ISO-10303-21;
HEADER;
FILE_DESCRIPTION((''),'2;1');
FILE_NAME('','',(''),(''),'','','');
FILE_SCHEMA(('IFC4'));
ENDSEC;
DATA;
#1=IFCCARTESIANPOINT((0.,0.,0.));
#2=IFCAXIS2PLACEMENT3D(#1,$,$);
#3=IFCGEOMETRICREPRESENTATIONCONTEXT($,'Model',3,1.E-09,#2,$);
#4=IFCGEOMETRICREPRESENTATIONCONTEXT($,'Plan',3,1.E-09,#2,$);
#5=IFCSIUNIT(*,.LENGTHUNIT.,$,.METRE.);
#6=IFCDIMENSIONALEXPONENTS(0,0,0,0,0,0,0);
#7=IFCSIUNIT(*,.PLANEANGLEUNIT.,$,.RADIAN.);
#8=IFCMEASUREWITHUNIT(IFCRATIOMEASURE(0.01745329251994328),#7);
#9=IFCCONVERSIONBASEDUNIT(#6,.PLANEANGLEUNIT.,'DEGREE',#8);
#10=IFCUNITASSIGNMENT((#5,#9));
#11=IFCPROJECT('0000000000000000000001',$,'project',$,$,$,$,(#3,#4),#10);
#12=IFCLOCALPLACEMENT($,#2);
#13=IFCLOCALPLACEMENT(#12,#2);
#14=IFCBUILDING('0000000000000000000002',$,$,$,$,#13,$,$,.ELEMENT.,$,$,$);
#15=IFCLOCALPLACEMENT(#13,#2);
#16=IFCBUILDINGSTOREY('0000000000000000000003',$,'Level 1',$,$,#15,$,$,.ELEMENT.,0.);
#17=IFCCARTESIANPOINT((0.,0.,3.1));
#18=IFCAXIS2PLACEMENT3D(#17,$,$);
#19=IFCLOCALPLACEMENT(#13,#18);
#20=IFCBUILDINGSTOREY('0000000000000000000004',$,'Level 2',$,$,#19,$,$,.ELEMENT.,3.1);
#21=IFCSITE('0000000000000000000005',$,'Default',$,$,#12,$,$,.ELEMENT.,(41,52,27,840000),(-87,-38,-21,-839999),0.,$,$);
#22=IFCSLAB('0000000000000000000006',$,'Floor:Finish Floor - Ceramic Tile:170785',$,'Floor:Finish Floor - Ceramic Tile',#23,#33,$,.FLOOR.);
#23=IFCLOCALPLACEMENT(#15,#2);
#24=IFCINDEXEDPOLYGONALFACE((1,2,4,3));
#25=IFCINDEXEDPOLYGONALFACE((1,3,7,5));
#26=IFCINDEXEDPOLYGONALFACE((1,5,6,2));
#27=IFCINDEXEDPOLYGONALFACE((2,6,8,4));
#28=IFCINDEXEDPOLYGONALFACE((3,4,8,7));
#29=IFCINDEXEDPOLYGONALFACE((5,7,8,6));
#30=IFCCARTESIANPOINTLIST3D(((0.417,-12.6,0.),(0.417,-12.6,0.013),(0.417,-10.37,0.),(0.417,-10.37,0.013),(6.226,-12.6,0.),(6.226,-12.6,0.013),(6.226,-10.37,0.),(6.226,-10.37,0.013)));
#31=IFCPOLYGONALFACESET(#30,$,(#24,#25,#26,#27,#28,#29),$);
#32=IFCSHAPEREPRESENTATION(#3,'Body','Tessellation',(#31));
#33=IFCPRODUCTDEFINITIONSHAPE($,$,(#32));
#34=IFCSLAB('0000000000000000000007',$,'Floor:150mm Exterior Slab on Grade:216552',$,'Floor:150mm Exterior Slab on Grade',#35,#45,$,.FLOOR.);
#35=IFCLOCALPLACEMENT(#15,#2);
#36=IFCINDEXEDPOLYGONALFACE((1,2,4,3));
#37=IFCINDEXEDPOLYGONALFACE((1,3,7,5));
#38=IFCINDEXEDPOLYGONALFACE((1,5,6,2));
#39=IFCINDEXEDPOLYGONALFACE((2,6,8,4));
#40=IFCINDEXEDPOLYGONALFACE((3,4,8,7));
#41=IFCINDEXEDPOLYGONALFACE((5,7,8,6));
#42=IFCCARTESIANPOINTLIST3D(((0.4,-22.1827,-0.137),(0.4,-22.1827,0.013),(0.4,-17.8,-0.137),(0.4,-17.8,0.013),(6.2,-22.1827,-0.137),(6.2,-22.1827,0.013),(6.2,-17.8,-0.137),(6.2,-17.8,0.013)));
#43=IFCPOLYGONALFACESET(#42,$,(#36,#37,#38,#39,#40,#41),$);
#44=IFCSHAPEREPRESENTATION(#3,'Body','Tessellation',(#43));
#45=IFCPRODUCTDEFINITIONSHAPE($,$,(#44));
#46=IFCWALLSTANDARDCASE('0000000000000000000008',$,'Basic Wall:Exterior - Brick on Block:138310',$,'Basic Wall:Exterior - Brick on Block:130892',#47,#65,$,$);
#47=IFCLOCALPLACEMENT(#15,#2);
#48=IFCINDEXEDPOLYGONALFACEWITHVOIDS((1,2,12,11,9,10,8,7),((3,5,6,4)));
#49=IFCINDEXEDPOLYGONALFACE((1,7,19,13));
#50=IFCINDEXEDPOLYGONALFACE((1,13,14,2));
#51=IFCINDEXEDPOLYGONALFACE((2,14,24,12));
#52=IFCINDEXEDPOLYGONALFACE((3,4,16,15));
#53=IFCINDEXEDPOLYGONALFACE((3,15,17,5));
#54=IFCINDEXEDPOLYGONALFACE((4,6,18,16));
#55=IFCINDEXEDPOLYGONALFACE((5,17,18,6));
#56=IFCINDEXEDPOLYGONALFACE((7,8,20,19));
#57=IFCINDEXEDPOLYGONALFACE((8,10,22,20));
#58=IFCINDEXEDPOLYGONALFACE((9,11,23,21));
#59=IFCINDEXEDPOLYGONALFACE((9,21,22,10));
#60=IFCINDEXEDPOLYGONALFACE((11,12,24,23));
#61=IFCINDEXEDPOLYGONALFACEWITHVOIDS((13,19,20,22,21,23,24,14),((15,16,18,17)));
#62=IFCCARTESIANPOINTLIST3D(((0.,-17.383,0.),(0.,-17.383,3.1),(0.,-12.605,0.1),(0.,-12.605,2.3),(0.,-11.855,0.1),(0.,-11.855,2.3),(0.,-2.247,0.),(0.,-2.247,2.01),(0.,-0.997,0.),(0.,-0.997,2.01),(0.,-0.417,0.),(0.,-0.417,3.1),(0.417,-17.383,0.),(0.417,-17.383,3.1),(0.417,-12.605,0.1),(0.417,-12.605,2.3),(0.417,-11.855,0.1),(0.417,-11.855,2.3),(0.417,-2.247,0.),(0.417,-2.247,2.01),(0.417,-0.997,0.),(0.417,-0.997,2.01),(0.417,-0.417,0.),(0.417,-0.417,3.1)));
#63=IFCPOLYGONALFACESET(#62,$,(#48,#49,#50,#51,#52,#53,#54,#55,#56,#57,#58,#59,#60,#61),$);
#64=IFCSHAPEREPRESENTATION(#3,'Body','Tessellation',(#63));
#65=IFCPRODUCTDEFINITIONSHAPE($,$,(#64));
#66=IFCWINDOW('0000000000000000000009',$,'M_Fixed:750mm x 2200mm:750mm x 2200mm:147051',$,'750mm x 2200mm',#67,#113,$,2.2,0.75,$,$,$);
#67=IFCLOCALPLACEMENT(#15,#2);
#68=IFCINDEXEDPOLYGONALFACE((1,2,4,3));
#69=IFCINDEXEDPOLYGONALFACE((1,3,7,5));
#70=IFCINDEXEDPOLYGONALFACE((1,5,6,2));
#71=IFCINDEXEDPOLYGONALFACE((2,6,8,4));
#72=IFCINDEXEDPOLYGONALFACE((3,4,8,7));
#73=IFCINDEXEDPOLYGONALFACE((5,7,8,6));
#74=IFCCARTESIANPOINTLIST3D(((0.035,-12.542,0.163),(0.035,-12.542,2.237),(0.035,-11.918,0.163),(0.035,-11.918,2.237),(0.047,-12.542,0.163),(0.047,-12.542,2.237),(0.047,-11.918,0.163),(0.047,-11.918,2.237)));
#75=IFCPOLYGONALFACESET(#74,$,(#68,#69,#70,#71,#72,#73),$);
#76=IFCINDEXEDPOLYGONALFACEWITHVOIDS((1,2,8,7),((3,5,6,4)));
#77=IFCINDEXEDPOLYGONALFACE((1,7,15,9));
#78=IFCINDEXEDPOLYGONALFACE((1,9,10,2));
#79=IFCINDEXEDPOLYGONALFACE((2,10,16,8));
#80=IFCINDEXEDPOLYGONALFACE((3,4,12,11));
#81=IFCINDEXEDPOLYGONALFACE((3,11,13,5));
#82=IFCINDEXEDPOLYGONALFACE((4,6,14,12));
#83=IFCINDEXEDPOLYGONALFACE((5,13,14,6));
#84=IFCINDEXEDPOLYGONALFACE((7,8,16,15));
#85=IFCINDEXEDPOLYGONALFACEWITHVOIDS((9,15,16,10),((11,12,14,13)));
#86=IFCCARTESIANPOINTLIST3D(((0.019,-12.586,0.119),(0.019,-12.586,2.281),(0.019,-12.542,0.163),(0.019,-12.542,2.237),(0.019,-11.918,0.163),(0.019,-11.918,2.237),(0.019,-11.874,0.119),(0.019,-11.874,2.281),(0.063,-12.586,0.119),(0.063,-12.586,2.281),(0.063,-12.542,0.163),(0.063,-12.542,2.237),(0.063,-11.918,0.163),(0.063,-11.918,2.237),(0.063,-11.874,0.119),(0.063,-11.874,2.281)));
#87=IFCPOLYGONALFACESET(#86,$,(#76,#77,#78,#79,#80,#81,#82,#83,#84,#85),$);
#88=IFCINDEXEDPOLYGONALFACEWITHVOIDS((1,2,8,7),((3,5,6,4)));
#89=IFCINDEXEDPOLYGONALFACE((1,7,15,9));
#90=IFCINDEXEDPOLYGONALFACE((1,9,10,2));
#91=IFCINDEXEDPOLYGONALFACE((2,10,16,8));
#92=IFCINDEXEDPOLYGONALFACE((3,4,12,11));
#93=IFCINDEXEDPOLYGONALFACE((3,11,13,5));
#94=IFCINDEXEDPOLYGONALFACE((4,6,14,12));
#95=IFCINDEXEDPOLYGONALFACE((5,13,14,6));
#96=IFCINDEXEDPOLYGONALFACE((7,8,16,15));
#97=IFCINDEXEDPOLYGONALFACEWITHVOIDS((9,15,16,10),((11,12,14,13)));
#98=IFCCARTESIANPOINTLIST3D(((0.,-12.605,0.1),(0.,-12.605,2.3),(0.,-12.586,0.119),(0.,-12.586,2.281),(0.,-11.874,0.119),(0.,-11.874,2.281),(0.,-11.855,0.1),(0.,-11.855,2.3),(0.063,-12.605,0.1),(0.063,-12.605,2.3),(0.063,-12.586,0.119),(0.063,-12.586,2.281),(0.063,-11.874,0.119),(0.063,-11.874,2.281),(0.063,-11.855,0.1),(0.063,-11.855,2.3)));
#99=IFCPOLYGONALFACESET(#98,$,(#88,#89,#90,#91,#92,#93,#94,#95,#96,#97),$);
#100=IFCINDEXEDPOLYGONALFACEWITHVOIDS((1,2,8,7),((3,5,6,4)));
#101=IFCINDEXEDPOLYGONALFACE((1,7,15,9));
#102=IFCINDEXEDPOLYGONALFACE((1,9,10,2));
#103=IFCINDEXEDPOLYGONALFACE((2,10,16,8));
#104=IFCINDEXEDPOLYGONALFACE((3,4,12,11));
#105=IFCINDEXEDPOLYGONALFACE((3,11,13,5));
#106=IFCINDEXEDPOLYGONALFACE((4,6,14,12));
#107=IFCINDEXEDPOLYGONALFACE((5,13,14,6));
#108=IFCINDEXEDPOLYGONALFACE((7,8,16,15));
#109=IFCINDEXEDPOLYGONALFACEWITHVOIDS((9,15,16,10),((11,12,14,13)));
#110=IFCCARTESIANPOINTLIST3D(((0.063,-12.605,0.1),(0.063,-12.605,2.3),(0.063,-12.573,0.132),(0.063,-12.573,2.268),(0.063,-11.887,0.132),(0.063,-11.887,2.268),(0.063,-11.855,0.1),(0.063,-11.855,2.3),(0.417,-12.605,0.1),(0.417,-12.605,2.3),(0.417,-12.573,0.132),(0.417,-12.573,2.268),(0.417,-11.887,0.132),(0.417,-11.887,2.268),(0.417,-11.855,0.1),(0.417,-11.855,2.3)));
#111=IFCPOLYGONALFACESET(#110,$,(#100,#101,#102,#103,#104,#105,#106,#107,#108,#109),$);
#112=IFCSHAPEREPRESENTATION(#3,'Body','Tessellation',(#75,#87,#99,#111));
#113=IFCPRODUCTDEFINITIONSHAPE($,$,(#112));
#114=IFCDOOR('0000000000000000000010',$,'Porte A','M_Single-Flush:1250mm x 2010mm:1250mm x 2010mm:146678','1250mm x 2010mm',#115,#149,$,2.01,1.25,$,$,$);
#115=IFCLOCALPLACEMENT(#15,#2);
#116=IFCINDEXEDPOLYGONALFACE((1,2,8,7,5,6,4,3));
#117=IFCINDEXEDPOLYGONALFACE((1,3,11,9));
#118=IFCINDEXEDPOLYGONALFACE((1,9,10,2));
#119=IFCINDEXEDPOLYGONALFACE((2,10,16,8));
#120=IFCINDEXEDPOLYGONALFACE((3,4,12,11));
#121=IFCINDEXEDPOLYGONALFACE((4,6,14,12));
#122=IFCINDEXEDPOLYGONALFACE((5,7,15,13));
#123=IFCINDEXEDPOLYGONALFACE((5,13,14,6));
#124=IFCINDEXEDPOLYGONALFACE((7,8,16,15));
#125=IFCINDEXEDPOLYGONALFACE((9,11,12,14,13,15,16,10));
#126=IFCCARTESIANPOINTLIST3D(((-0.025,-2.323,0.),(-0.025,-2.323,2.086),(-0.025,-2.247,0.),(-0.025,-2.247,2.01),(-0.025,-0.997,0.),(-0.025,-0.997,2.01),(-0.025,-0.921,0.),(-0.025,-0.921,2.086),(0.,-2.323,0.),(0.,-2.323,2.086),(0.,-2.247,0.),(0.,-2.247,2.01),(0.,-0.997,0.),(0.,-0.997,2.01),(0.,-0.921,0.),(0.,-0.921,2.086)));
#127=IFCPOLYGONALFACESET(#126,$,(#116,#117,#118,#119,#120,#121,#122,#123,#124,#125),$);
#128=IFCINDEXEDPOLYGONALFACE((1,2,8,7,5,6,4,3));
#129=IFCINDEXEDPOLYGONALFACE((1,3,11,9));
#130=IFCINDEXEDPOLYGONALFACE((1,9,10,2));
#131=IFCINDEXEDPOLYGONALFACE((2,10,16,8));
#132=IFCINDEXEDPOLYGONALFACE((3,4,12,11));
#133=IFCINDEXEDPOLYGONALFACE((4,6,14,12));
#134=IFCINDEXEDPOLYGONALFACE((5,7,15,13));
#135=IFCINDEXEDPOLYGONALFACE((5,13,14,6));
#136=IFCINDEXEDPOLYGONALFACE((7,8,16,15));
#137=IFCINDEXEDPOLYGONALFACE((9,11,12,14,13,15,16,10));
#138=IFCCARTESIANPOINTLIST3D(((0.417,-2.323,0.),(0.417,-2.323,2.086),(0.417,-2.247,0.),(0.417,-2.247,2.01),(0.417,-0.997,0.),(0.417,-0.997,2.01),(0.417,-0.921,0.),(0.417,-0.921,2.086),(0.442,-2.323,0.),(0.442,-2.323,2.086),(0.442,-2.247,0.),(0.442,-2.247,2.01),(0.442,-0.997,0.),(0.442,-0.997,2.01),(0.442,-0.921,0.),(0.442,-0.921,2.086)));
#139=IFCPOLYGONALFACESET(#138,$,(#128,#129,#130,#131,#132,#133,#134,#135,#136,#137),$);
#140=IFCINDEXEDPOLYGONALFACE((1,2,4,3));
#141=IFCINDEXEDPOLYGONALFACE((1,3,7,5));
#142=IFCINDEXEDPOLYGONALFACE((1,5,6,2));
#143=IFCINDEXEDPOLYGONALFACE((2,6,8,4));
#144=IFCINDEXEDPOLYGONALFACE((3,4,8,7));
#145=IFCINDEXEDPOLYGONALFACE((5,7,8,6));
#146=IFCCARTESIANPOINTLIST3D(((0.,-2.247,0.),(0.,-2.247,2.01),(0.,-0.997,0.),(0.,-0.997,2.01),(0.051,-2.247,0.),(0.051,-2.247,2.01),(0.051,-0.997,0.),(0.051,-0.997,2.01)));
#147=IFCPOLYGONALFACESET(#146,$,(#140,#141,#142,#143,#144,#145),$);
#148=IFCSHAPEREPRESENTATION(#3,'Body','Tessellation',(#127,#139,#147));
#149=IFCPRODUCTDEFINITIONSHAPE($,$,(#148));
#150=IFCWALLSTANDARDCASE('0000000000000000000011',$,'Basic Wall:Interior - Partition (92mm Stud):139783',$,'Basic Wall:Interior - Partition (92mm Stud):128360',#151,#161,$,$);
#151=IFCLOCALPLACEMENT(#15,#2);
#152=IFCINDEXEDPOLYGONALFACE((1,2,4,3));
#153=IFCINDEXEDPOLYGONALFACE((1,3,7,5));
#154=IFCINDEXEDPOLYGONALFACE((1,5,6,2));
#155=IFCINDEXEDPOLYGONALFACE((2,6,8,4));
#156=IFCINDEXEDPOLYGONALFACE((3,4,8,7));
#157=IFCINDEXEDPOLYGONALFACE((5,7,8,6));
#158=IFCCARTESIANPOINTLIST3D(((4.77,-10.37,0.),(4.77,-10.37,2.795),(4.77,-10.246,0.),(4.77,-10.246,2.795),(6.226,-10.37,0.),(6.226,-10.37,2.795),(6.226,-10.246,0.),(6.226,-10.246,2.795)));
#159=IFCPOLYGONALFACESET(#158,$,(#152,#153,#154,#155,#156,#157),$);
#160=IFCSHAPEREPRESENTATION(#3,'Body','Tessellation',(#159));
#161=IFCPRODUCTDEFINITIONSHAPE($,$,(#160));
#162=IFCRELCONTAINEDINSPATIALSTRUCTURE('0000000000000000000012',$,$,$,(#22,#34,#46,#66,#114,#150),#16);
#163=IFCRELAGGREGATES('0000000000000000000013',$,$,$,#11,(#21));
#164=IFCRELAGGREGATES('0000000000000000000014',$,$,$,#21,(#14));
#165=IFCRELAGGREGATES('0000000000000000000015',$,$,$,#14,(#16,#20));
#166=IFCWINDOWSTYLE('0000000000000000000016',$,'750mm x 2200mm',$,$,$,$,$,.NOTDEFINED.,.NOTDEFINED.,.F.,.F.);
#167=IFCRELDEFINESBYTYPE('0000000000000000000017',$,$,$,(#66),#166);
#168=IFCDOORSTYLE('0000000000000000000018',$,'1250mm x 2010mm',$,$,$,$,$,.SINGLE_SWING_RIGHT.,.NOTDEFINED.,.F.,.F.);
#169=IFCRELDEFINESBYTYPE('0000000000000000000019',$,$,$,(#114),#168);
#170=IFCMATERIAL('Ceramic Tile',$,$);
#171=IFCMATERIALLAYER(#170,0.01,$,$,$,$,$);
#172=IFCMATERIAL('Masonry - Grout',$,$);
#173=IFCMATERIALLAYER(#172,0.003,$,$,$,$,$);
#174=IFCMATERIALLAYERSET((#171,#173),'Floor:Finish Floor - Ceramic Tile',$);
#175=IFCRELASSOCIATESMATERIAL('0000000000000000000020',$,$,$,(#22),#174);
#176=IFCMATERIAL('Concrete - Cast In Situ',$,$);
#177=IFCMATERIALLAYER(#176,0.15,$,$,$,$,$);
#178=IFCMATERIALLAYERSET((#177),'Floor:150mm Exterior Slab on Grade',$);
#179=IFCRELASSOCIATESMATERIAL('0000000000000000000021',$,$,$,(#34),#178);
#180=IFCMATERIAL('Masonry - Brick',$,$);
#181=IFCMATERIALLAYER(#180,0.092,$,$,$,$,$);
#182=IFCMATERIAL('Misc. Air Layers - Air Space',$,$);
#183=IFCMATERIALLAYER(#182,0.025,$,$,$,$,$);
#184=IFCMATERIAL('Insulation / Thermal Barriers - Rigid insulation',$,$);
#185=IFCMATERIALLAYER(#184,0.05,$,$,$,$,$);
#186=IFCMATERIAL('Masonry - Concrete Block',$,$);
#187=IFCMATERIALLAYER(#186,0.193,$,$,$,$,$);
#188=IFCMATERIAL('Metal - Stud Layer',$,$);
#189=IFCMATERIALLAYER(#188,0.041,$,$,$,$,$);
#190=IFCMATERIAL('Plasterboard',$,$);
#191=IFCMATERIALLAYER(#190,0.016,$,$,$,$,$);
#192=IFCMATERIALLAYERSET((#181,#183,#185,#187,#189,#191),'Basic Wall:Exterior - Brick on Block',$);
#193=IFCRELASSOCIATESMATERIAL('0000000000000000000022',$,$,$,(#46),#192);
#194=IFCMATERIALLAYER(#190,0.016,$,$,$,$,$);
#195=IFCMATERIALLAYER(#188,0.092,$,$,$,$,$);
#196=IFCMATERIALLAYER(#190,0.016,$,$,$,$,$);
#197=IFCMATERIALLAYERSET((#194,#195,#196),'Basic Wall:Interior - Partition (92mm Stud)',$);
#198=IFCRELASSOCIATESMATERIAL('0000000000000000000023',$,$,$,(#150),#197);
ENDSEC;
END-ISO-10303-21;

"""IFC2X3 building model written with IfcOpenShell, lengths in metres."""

from ifc_helpers import new_model, entity, si_unit, converted_unit, frame, frame_2d, origin, origin_2d_with_axis, place, context, project, spatial, polyline, rectangle, outline, extrude, source, transform, mapped, material, layer, layer_set, layer_usage, type_object, type_shapes, element, fill, save


model = new_model("IFC2X3")

# Units and contexts
model_context = context("Model", 3, precision=1e-09, world=origin())
plan_context = context("Plan", 3, precision=1e-09, world=origin())
ifc_project = project(units=[si_unit("LENGTHUNIT", "METRE"), converted_unit("PLANEANGLEUNIT", "DEGREE", entity("IfcRatioMeasure", 0.01745329251994328), si_unit("PLANEANGLEUNIT", "RADIAN"), dimensions=[0, 0, 0, 0, 0, 0, 0])], contexts=[model_context, plan_context])

# Site, building, storey
site_placement = place(None, origin())
site = spatial("IfcSite", under=ifc_project, at=site_placement, Name="Default", CompositionType="ELEMENT", RefLatitude=(41, 52, 27, 840000), RefLongitude=(-87, -38, -21, -839999), RefElevation=0.0)
building_placement = place(site_placement, origin())
building = spatial("IfcBuilding", under=site, at=building_placement, CompositionType="ELEMENT")
storey_1_placement = place(building_placement, origin())
storey_1 = spatial("IfcBuildingStorey", under=building, at=storey_1_placement, Name="Level 1", CompositionType="ELEMENT", Elevation=0.0)

# Slabs
ifc_material_1 = material(Name="Ceramic Tile")
ifc_layer_1 = layer(ifc_material_1, 0.01)
ifc_material_2 = material(Name="Masonry - Grout")
ifc_layer_2 = layer(ifc_material_2, 0.003)
ifc_layer_set_1 = layer_set([ifc_layer_1, ifc_layer_2], Name="Floor:Finish Floor - Ceramic Tile")
ifc_layer_usage_1 = layer_usage(ifc_layer_set_1, "AXIS3", "POSITIVE", 0.0)
slab_1_placement = place(storey_1_placement, frame((0.417, -12.6, 0.0)))
element("IfcSlab", 1, at=slab_1_placement, inside=storey_1, material=ifc_layer_usage_1, Name="Floor:Finish Floor - Ceramic Tile:170785", ObjectType="Floor:Finish Floor - Ceramic Tile", PredefinedType="FLOOR", context=model_context, shape_type="SweptSolid", body=[
    extrude(rectangle(XDim=5.809, YDim=2.23, at=frame_2d((0.0, 0.0), x_axis=(-1.0, 0.0))), frame((2.9045, 1.115, 0.013), z_axis=(0.0, 0.0, -1.0), x_axis=(-1.0, 0.0, 0.0)), (0.0, 0.0, 1.0), 0.013),
])
ifc_material_3 = material(Name="Concrete - Cast In Situ")
ifc_layer_3 = layer(ifc_material_3, 0.15)
ifc_layer_set_2 = layer_set([ifc_layer_3], Name="Floor:150mm Exterior Slab on Grade")
ifc_layer_usage_2 = layer_usage(ifc_layer_set_2, "AXIS3", "POSITIVE", 0.0)
slab_2_placement = place(storey_1_placement, frame((0.4, -22.1827, -0.137)))
element("IfcSlab", 2, at=slab_2_placement, inside=storey_1, material=ifc_layer_usage_2, Name="Floor:150mm Exterior Slab on Grade:216552", ObjectType="Floor:150mm Exterior Slab on Grade", PredefinedType="FLOOR", context=model_context, shape_type="SweptSolid", body=[
    extrude(rectangle(XDim=5.8, YDim=4.3827, at=origin_2d_with_axis()), frame((2.9, 2.1914, 0.15), z_axis=(0.0, 0.0, -1.0), x_axis=(-1.0, 0.0, 0.0)), (0.0, 0.0, 1.0), 0.15),
])

# Wall, openings, window, door
ifc_material_4 = material(Name="Masonry - Brick")
ifc_layer_4 = layer(ifc_material_4, 0.092)
ifc_material_5 = material(Name="Misc. Air Layers - Air Space")
ifc_layer_5 = layer(ifc_material_5, 0.025)
ifc_material_6 = material(Name="Insulation / Thermal Barriers - Rigid insulation")
ifc_layer_6 = layer(ifc_material_6, 0.05)
ifc_material_7 = material(Name="Masonry - Concrete Block")
ifc_layer_7 = layer(ifc_material_7, 0.193)
ifc_material_8 = material(Name="Metal - Stud Layer")
ifc_layer_8 = layer(ifc_material_8, 0.041)
ifc_material_9 = material(Name="Plasterboard")
ifc_layer_9 = layer(ifc_material_9, 0.016)
ifc_layer_set_3 = layer_set([ifc_layer_4, ifc_layer_5, ifc_layer_6, ifc_layer_7, ifc_layer_8, ifc_layer_9], Name="Basic Wall:Exterior - Brick on Block")
ifc_layer_usage_3 = layer_usage(ifc_layer_set_3, "AXIS2", "NEGATIVE", 0.2085)
wall_1_placement = place(storey_1_placement, frame((0.2085, -17.383, 0.0), z_axis=(0.0, 0.0, 1.0), x_axis=(0.0, 1.0, 0.0)))
wall_1 = element("IfcWallStandardCase", 3, at=wall_1_placement, inside=storey_1, material=ifc_layer_usage_3, Name="Basic Wall:Exterior - Brick on Block:138310", ObjectType="Basic Wall:Exterior - Brick on Block:130892", context=model_context, shape_type="SweptSolid", body=[
    extrude(rectangle(XDim=16.966, YDim=0.417, at=frame_2d((8.483, 0.0), x_axis=(-1.0, 0.0))), origin(), (0.0, 0.0, 1.0), 3.1),
])
opening_1_placement = place(wall_1_placement, frame((15.136, -0.2085, 0.0)))
opening_1 = element("IfcOpeningElement", 4, at=opening_1_placement, cuts=wall_1, ObjectType="Opening", context=model_context, shape_type="SweptSolid", body=[
    extrude(rectangle(XDim=1.25, YDim=2.01, at=frame_2d((1.005, 0.625), x_axis=(0.0, 1.0))), frame((0.0, 0.0, 0.0), z_axis=(0.0, 1.0, 0.0), x_axis=(0.0, 0.0, 1.0)), (0.0, 0.0, 1.0), 0.417),
])
opening_2_placement = place(wall_1_placement, frame((4.778, -0.2085, 0.1)))
opening_2 = element("IfcOpeningElement", 5, at=opening_2_placement, cuts=wall_1, ObjectType="Opening", context=model_context, shape_type="SweptSolid", body=[
    extrude(rectangle(XDim=2.2, YDim=0.75, at=frame_2d((1.1, 0.375), x_axis=(1.0, 0.0))), frame((0.0, 0.0, 0.0), z_axis=(0.0, 1.0, 0.0), x_axis=(0.0, 0.0, 1.0)), (0.0, 0.0, 1.0), 0.417),
])
window_style_1 = type_object("IfcWindowStyle", Name="750mm x 2200mm", ConstructionType="NOTDEFINED", OperationType="NOTDEFINED", ParameterTakesPrecedence=False, Sizeable=False)
shared_shape_1 = source(origin(), model_context, "Body", "SweptSolid", [
    extrude(rectangle(XDim=0.012, YDim=0.624, at=origin_2d_with_axis()), frame((0.375, 0.376, 0.063), z_axis=(0.0, 0.0, 1.0), x_axis=(0.0, -1.0, 0.0)), (0.0, 0.0, 1.0), 2.074),
    extrude(outline(polyline([(-0.356, -1.081), (0.356, -1.081), (0.356, 1.081), (-0.356, 1.081), (-0.356, -1.081)]), holes=[polyline([(-0.312, -1.037), (-0.312, 1.037), (0.312, 1.037), (0.312, -1.037), (-0.312, -1.037)])]), frame((0.375, 0.354, 1.1), z_axis=(0.0, 1.0, 0.0), x_axis=(1.0, 0.0, 0.0)), (0.0, 0.0, 1.0), 0.044),
    extrude(outline(polyline([(-0.375, -1.1), (0.375, -1.1), (0.375, 1.1), (-0.375, 1.1), (-0.375, -1.1)]), holes=[polyline([(-0.356, -1.081), (-0.356, 1.081), (0.356, 1.081), (0.356, -1.081), (-0.356, -1.081)])]), frame((0.375, 0.354, 1.1), z_axis=(0.0, 1.0, 0.0), x_axis=(1.0, 0.0, 0.0)), (0.0, 0.0, 1.0), 0.063),
    extrude(outline(polyline([(-0.375, -1.1), (0.375, -1.1), (0.375, 1.1), (-0.375, 1.1), (-0.375, -1.1)]), holes=[polyline([(-0.343, -1.068), (-0.343, 1.068), (0.343, 1.068), (0.343, -1.068), (-0.343, -1.068)])]), frame((0.375, 0.0, 1.1), z_axis=(0.0, 1.0, 0.0), x_axis=(1.0, 0.0, 0.0)), (0.0, 0.0, 1.0), 0.354),
])
type_shapes(window_style_1, [shared_shape_1])
window_1_placement = place(opening_2_placement, origin())
window_1 = element("IfcWindow", 6, at=window_1_placement, inside=storey_1, type_object=window_style_1, Name="M_Fixed:750mm x 2200mm:750mm x 2200mm:147051", ObjectType="750mm x 2200mm", OverallHeight=2.2, OverallWidth=0.75, context=model_context, shape_type="MappedRepresentation", body=[
    mapped(shared_shape_1, transform((0.0, 0.0, 0.0), scale=1.0)),
])
fill(opening_2, window_1)
door_style_1 = type_object("IfcDoorStyle", Name="1250mm x 2010mm", ConstructionType="NOTDEFINED", OperationType="SINGLE_SWING_RIGHT", ParameterTakesPrecedence=False, Sizeable=False)
shared_shape_2 = source(origin(), model_context, "Body", "SweptSolid", [
    extrude(outline(polyline([(-0.701, -1.062), (0.701, -1.062), (0.701, 1.024), (0.625, 1.024), (0.625, -0.986), (-0.625, -0.986), (-0.625, 1.024), (-0.701, 1.024), (-0.701, -1.062)])), frame((0.625, 0.417, 1.024), z_axis=(0.0, 1.0, 0.0), x_axis=(1.0, 0.0, 0.0)), (0.0, 0.0, 1.0), 0.025),
    extrude(outline(polyline([(-1.062, -0.701), (1.024, -0.701), (1.024, -0.625), (-0.986, -0.625), (-0.986, 0.625), (1.024, 0.625), (1.024, 0.701), (-1.062, 0.701), (-1.062, -0.701)])), frame((0.625, -0.025, 1.024), z_axis=(0.0, 1.0, 0.0), x_axis=(0.0, 0.0, -1.0)), (0.0, 0.0, 1.0), 0.025),
    extrude(rectangle(XDim=0.051, YDim=1.25, at=origin_2d_with_axis()), frame((0.625, 0.3915, 0.0), z_axis=(0.0, 0.0, 1.0), x_axis=(0.0, 1.0, 0.0)), (0.0, 0.0, 1.0), 2.01),
])
type_shapes(door_style_1, [shared_shape_2])
door_1_placement = place(opening_1_placement, origin())
door_1 = element("IfcDoor", 7, at=door_1_placement, inside=storey_1, type_object=door_style_1, Name="Porte A", Description="M_Single-Flush:1250mm x 2010mm:1250mm x 2010mm:146678", ObjectType="1250mm x 2010mm", OverallHeight=2.01, OverallWidth=1.25, context=model_context, shape_type="MappedRepresentation", body=[
    mapped(shared_shape_2, transform((0.0, 0.0, 0.0), scale=1.0)),
])
fill(opening_1, door_1)

# Wall
ifc_layer_10 = layer(ifc_material_9, 0.016)
ifc_layer_11 = layer(ifc_material_8, 0.092)
ifc_layer_12 = layer(ifc_material_9, 0.016)
ifc_layer_set_4 = layer_set([ifc_layer_10, ifc_layer_11, ifc_layer_12], Name="Basic Wall:Interior - Partition (92mm Stud)")
ifc_layer_usage_4 = layer_usage(ifc_layer_set_4, "AXIS2", "NEGATIVE", 0.062)
wall_2_placement = place(storey_1_placement, frame((4.77, -10.308, 0.0)))
element("IfcWallStandardCase", 8, at=wall_2_placement, inside=storey_1, material=ifc_layer_usage_4, Name="Basic Wall:Interior - Partition (92mm Stud):139783", ObjectType="Basic Wall:Interior - Partition (92mm Stud):128360", context=model_context, shape_type="SweptSolid", body=[
    extrude(rectangle(XDim=1.456, YDim=0.124, at=frame_2d((0.728, 0.0), x_axis=(-1.0, 0.0))), origin(), (0.0, 0.0, 1.0), 2.795),
])

# Shared definitions
storey_2_placement = place(building_placement, frame((0.0, 0.0, 3.1)))
storey_2 = spatial("IfcBuildingStorey", under=building, at=storey_2_placement, Name="Level 2", CompositionType="ELEMENT", Elevation=3.1)

save(model, "model.ifc")
